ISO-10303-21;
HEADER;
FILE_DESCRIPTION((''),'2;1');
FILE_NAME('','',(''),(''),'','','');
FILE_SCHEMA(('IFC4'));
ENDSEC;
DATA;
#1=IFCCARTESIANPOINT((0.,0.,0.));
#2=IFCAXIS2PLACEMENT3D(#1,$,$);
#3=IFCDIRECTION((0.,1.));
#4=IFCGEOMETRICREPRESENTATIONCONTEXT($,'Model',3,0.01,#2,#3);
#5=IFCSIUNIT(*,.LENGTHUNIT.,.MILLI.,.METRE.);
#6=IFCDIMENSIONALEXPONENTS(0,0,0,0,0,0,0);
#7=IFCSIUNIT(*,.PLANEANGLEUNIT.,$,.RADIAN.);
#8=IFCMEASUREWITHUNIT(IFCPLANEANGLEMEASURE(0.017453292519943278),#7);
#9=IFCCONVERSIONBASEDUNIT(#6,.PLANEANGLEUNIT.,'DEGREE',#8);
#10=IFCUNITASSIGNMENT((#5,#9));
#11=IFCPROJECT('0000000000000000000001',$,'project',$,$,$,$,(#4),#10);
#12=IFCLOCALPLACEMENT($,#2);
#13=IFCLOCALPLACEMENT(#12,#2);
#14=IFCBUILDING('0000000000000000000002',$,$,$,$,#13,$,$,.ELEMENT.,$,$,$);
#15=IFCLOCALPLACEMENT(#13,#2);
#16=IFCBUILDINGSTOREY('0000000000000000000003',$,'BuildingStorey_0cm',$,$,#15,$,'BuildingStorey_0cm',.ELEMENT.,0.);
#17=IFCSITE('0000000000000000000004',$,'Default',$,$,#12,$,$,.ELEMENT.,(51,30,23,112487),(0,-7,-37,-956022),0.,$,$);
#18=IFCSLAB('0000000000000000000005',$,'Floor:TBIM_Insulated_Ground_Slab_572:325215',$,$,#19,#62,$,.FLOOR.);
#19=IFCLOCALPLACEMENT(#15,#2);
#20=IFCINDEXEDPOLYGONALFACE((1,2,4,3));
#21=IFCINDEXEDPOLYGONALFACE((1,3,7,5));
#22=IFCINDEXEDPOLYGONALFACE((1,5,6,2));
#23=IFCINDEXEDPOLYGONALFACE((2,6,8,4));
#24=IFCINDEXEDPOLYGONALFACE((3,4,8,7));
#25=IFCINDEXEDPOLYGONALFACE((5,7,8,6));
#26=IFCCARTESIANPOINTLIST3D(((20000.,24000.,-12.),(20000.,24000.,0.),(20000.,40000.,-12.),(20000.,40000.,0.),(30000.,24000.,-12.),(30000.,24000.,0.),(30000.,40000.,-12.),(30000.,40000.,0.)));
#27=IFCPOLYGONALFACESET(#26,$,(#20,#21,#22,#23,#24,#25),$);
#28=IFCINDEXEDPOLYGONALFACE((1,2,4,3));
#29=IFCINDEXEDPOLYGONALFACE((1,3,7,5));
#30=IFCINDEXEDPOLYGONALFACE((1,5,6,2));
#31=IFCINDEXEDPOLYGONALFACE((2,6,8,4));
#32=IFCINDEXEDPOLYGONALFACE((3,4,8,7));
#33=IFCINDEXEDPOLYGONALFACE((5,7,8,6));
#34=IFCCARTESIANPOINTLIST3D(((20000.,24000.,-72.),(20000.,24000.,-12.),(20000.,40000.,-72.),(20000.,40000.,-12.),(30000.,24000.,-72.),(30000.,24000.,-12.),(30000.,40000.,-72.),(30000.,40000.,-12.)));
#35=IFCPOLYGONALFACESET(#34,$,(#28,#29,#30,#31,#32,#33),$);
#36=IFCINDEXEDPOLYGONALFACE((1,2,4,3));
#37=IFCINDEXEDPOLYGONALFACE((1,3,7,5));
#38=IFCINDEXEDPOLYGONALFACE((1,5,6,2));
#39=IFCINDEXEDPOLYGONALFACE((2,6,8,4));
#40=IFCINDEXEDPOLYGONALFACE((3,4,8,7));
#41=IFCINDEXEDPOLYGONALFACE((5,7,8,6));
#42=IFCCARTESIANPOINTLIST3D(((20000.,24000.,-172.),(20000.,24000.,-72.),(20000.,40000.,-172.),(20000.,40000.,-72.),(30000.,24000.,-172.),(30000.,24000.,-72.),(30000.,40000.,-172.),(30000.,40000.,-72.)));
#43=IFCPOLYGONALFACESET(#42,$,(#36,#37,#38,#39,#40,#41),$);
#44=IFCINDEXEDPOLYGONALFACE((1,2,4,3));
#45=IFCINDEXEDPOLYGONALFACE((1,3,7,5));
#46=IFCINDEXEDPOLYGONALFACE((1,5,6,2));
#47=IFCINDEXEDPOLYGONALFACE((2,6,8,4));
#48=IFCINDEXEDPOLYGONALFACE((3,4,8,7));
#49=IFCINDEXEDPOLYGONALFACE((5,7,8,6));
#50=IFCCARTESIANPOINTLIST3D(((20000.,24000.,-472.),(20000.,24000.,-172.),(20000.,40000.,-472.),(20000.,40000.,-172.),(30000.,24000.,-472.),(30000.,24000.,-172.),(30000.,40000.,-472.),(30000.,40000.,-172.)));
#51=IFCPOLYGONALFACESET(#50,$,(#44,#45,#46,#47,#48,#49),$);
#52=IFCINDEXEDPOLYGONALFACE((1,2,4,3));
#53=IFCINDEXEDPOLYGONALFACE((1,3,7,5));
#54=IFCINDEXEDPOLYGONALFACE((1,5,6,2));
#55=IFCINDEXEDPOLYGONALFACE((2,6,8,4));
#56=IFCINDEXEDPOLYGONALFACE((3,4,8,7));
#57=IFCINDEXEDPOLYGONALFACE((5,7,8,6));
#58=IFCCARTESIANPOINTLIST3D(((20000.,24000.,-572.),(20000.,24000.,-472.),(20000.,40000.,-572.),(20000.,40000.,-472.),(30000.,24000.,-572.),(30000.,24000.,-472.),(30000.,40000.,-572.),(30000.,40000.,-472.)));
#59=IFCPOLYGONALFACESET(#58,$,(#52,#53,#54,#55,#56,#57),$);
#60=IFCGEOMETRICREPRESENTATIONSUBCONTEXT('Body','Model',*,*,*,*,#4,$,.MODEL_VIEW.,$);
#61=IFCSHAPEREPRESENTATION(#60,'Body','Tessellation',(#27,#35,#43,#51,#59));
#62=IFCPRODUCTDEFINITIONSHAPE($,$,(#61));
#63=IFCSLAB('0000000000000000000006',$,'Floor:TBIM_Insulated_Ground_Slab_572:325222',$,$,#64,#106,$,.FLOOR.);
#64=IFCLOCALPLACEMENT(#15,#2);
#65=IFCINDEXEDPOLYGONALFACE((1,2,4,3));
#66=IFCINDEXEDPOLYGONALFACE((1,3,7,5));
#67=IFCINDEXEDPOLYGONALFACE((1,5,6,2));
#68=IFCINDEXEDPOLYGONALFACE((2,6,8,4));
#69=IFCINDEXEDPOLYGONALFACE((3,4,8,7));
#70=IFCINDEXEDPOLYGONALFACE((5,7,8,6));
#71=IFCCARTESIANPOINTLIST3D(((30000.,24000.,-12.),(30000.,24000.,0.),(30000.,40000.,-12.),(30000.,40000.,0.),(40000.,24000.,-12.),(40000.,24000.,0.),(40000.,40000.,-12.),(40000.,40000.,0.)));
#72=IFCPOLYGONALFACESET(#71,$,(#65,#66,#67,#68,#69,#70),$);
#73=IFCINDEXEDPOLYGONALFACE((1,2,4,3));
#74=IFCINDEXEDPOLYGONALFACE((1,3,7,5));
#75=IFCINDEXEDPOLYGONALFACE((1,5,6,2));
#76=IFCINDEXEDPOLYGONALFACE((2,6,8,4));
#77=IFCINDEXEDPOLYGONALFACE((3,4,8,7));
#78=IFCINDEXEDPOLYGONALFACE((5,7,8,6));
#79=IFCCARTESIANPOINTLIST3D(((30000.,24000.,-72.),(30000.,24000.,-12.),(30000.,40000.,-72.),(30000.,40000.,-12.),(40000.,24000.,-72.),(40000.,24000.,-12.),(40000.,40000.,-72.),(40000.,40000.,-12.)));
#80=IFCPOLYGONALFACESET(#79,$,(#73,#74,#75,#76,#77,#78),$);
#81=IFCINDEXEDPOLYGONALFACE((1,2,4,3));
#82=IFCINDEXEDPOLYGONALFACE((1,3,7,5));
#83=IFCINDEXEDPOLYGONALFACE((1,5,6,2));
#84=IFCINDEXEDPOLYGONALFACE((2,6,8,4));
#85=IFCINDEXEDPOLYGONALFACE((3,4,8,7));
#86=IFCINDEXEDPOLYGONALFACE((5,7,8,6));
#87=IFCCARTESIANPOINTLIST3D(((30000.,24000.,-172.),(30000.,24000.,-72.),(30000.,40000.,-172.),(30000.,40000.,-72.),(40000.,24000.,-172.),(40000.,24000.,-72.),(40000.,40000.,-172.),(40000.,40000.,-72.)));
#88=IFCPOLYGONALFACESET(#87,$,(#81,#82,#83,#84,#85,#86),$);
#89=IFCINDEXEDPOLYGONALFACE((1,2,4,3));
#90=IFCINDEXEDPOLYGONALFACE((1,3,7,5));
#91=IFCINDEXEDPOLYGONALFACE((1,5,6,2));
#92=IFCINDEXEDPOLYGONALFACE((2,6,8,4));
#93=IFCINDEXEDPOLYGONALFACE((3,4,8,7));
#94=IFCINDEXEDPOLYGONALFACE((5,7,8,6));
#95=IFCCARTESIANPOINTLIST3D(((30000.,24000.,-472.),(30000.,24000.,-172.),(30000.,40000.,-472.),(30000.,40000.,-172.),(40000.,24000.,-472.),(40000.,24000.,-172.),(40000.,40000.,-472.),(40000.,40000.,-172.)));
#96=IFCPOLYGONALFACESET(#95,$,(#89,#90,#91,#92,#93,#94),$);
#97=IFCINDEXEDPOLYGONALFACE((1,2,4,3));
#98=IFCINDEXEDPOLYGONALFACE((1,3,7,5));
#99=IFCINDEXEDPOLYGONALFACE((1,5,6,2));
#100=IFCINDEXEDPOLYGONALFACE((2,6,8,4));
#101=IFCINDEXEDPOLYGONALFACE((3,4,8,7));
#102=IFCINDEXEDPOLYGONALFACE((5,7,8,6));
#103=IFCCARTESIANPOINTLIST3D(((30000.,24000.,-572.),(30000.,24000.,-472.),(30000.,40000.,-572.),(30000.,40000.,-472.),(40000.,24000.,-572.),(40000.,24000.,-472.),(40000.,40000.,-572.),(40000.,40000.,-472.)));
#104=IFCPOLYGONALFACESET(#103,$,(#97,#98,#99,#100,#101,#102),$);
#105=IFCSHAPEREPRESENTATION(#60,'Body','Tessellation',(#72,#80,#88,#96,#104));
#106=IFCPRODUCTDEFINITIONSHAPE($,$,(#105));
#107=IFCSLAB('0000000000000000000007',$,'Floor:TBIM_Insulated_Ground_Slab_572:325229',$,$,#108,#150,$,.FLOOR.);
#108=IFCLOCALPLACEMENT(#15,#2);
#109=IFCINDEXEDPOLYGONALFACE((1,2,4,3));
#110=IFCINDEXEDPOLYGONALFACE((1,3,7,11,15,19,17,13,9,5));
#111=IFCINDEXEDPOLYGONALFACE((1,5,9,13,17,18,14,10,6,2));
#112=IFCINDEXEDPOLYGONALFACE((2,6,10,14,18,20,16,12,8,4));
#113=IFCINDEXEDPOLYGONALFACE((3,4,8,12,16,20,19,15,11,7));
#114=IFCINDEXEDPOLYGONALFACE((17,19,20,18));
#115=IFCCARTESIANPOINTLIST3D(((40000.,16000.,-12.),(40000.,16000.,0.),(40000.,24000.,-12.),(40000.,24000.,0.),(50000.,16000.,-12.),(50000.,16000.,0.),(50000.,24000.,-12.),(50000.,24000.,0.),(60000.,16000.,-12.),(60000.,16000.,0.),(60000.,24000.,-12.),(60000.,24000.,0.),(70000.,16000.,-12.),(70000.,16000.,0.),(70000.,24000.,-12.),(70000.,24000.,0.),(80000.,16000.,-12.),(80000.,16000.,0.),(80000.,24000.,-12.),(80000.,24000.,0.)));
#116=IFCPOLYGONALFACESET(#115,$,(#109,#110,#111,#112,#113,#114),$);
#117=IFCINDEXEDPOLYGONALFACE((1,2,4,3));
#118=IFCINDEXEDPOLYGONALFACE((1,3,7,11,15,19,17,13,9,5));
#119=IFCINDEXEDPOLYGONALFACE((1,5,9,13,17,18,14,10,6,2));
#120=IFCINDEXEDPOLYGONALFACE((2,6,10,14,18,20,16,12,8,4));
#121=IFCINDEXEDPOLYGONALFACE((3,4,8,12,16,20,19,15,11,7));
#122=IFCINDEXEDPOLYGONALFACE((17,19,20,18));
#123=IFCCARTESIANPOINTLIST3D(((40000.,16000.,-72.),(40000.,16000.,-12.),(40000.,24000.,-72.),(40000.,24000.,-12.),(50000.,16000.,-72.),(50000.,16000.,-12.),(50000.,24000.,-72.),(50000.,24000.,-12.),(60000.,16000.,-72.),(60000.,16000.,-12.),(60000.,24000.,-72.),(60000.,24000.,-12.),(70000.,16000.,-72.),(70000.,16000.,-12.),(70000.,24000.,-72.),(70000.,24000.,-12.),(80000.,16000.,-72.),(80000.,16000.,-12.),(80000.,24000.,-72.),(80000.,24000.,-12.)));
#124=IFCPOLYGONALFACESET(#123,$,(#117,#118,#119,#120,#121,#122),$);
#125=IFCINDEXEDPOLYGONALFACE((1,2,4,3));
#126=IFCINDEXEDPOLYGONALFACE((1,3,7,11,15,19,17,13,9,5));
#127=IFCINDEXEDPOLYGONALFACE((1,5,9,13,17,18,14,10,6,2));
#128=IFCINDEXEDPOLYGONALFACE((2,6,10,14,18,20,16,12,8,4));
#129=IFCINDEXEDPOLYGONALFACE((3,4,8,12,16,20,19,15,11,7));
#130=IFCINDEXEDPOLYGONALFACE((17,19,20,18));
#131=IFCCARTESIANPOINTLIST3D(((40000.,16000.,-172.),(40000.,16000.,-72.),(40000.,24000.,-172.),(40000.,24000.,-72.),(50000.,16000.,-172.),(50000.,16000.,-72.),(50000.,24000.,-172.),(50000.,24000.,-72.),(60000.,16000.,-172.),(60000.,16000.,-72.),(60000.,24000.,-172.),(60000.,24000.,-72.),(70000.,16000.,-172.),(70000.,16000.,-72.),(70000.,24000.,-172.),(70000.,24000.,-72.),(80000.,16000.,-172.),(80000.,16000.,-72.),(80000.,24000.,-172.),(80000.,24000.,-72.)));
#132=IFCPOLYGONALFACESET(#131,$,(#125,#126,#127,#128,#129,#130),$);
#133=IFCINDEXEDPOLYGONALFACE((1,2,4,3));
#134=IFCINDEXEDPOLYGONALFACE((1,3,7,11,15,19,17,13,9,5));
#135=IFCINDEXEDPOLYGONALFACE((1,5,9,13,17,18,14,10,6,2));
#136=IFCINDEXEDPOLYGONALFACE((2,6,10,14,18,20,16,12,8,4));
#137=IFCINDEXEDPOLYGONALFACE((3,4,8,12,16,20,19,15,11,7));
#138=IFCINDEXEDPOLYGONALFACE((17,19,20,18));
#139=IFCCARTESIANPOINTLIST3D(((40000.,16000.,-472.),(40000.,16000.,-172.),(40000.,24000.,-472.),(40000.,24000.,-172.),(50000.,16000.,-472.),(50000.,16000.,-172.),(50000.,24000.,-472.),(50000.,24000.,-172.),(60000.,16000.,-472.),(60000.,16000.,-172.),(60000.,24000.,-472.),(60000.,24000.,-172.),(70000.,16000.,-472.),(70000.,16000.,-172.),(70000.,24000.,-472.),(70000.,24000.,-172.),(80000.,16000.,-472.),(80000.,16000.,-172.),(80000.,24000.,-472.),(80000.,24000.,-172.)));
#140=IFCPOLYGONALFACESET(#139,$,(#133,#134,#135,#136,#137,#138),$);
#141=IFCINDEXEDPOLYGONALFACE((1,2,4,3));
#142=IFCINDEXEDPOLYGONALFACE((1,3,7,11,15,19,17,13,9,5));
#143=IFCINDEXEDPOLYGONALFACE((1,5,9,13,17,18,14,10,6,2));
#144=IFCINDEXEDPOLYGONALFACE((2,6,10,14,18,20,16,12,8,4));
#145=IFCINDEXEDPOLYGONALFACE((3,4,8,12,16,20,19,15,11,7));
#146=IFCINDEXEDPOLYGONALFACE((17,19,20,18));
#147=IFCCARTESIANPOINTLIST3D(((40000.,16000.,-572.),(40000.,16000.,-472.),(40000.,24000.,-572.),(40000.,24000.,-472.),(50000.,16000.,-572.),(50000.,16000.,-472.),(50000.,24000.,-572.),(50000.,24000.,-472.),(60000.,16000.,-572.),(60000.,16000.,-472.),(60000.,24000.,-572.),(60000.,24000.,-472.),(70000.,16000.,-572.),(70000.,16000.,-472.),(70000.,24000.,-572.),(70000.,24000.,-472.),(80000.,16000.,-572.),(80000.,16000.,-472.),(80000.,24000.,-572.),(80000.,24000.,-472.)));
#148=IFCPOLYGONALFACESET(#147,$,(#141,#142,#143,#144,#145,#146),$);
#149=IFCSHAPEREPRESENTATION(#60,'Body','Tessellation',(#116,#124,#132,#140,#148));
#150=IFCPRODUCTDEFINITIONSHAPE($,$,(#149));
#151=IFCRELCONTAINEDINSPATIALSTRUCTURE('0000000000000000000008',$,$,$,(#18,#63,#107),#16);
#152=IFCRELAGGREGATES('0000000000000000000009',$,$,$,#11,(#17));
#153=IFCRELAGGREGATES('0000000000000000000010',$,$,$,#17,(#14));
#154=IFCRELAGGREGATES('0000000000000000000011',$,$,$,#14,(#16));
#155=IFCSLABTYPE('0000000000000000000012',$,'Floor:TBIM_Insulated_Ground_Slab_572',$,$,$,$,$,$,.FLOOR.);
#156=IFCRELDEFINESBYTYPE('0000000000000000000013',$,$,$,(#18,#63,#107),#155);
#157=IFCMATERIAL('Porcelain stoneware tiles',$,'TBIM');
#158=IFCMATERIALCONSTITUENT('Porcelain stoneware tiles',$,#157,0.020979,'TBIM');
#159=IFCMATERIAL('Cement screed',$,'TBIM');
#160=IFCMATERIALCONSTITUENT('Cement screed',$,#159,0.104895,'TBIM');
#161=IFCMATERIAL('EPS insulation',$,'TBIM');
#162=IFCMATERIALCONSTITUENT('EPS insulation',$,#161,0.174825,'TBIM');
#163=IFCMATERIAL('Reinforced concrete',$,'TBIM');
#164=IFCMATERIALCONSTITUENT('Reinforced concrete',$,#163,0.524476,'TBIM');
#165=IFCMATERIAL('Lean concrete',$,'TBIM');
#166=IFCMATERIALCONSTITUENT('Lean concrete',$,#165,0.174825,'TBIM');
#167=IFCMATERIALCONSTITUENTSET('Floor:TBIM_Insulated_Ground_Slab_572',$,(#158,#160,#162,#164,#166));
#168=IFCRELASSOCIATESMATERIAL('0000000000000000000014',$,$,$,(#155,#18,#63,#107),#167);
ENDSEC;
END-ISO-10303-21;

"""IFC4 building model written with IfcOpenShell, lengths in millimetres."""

from ifc_helpers import new_model, entity, si_unit, converted_unit, direction, frame, origin, place, context, subcontext, project, spatial, indexed_curve, outline, extrude, material, constituent, constituent_set, type_object, element, save


model = new_model("IFC4")

# Units and contexts
model_context = context("Model", 3, precision=0.01, world=origin(), true_north=direction((0.0, 1.0)))
body_context = subcontext(model_context, "Body", "Model", "MODEL_VIEW")
ifc_project = project(units=[si_unit("LENGTHUNIT", "METRE", prefix="MILLI"), converted_unit("PLANEANGLEUNIT", "DEGREE", entity("IfcPlaneAngleMeasure", 0.017453292519943278), si_unit("PLANEANGLEUNIT", "RADIAN"), dimensions=[0, 0, 0, 0, 0, 0, 0])], contexts=[model_context])

# Site, building, storey
site_placement = place(None, origin())
site = spatial("IfcSite", under=ifc_project, at=site_placement, Name="Default", CompositionType="ELEMENT", RefLatitude=(51, 30, 23, 112487), RefLongitude=(0, -7, -37, -956022), RefElevation=0.0)
building_placement = place(site_placement, origin())
building = spatial("IfcBuilding", under=site, at=building_placement, CompositionType="ELEMENT")
storey_placement = place(building_placement, origin())
storey = spatial("IfcBuildingStorey", under=building, at=storey_placement, Name="BuildingStorey_0cm", LongName="BuildingStorey_0cm", CompositionType="ELEMENT", Elevation=0.0)

# Slabs
ifc_material_1 = material(Name="Porcelain stoneware tiles", Category="TBIM")
ifc_constituent_1 = constituent(ifc_material_1, Name="Porcelain stoneware tiles", Category="TBIM", fraction=0.020979)
ifc_material_2 = material(Name="Cement screed", Category="TBIM")
ifc_constituent_2 = constituent(ifc_material_2, Name="Cement screed", Category="TBIM", fraction=0.104895)
ifc_material_3 = material(Name="EPS insulation", Category="TBIM")
ifc_constituent_3 = constituent(ifc_material_3, Name="EPS insulation", Category="TBIM", fraction=0.174825)
ifc_material_4 = material(Name="Reinforced concrete", Category="TBIM")
ifc_constituent_4 = constituent(ifc_material_4, Name="Reinforced concrete", Category="TBIM", fraction=0.524476)
ifc_material_5 = material(Name="Lean concrete", Category="TBIM")
ifc_constituent_5 = constituent(ifc_material_5, Name="Lean concrete", Category="TBIM", fraction=0.174825)
ifc_constituent_set_1 = constituent_set(constituents=[ifc_constituent_1, ifc_constituent_2, ifc_constituent_3, ifc_constituent_4, ifc_constituent_5], Name="Floor:TBIM_Insulated_Ground_Slab_572")
slab_type = type_object("IfcSlabType", Name="Floor:TBIM_Insulated_Ground_Slab_572", PredefinedType="FLOOR", material=ifc_constituent_set_1)
slab_1_placement = place(storey_placement, origin())
element("IfcSlab", 1, at=slab_1_placement, inside=storey, type_object=slab_type, material=ifc_constituent_set_1, Name="Floor:TBIM_Insulated_Ground_Slab_572:325215", PredefinedType="FLOOR", context=body_context, shape_type="SweptSolid", body=[
    extrude(outline(indexed_curve([(-5000.0, -8000.0), (5000.0, -8000.0), (5000.0, 8000.0), (-5000.0, 8000.0), (-5000.0, -8000.0)], self_intersect=False)), frame((25000.0, 32000.0, -12.0), z_axis=(0.0, 0.0, 1.0), x_axis=(-1.0, 0.0, 0.0)), (0.0, 0.0, 1.0), 12.0),
    extrude(outline(indexed_curve([(-5000.0, -8000.0), (5000.0, -8000.0), (5000.0, 8000.0), (-5000.0, 8000.0), (-5000.0, -8000.0)], self_intersect=False)), frame((25000.0, 32000.0, -72.0), z_axis=(0.0, 0.0, 1.0), x_axis=(-1.0, 0.0, 0.0)), (0.0, 0.0, 1.0), 60.0),
    extrude(outline(indexed_curve([(-5000.0, -8000.0), (5000.0, -8000.0), (5000.0, 8000.0), (-5000.0, 8000.0), (-5000.0, -8000.0)], self_intersect=False)), frame((25000.0, 32000.0, -172.0), z_axis=(0.0, 0.0, 1.0), x_axis=(-1.0, 0.0, 0.0)), (0.0, 0.0, 1.0), 100.0),
    extrude(outline(indexed_curve([(-5000.0, -8000.0), (5000.0, -8000.0), (5000.0, 8000.0), (-5000.0, 8000.0), (-5000.0, -8000.0)], self_intersect=False)), frame((25000.0, 32000.0, -472.0), z_axis=(0.0, 0.0, 1.0), x_axis=(-1.0, 0.0, 0.0)), (0.0, 0.0, 1.0), 300.0),
    extrude(outline(indexed_curve([(-5000.0, -8000.0), (5000.0, -8000.0), (5000.0, 8000.0), (-5000.0, 8000.0), (-5000.0, -8000.0)], self_intersect=False)), frame((25000.0, 32000.0, -572.0), z_axis=(0.0, 0.0, 1.0), x_axis=(-1.0, 0.0, 0.0)), (0.0, 0.0, 1.0), 100.0),
])
slab_2_placement = place(storey_placement, origin())
element("IfcSlab", 2, at=slab_2_placement, inside=storey, type_object=slab_type, material=ifc_constituent_set_1, Name="Floor:TBIM_Insulated_Ground_Slab_572:325222", PredefinedType="FLOOR", context=body_context, shape_type="SweptSolid", body=[
    extrude(outline(indexed_curve([(-5000.0, -8000.0), (5000.0, -8000.0), (5000.0, 8000.0), (-5000.0, 8000.0), (-5000.0, -8000.0)], self_intersect=False)), frame((35000.0, 32000.0, -12.0), z_axis=(0.0, 0.0, 1.0), x_axis=(-1.0, 0.0, 0.0)), (0.0, 0.0, 1.0), 12.0),
    extrude(outline(indexed_curve([(-5000.0, -8000.0), (5000.0, -8000.0), (5000.0, 8000.0), (-5000.0, 8000.0), (-5000.0, -8000.0)], self_intersect=False)), frame((35000.0, 32000.0, -72.0), z_axis=(0.0, 0.0, 1.0), x_axis=(-1.0, 0.0, 0.0)), (0.0, 0.0, 1.0), 60.0),
    extrude(outline(indexed_curve([(-5000.0, -8000.0), (5000.0, -8000.0), (5000.0, 8000.0), (-5000.0, 8000.0), (-5000.0, -8000.0)], self_intersect=False)), frame((35000.0, 32000.0, -172.0), z_axis=(0.0, 0.0, 1.0), x_axis=(-1.0, 0.0, 0.0)), (0.0, 0.0, 1.0), 100.0),
    extrude(outline(indexed_curve([(-5000.0, -8000.0), (5000.0, -8000.0), (5000.0, 8000.0), (-5000.0, 8000.0), (-5000.0, -8000.0)], self_intersect=False)), frame((35000.0, 32000.0, -472.0), z_axis=(0.0, 0.0, 1.0), x_axis=(-1.0, 0.0, 0.0)), (0.0, 0.0, 1.0), 300.0),
    extrude(outline(indexed_curve([(-5000.0, -8000.0), (5000.0, -8000.0), (5000.0, 8000.0), (-5000.0, 8000.0), (-5000.0, -8000.0)], self_intersect=False)), frame((35000.0, 32000.0, -572.0), z_axis=(0.0, 0.0, 1.0), x_axis=(-1.0, 0.0, 0.0)), (0.0, 0.0, 1.0), 100.0),
])
slab_3_placement = place(storey_placement, origin())
element("IfcSlab", 3, at=slab_3_placement, inside=storey, type_object=slab_type, material=ifc_constituent_set_1, Name="Floor:TBIM_Insulated_Ground_Slab_572:325229", PredefinedType="FLOOR", context=body_context, shape_type="SweptSolid", body=[
    extrude(outline(indexed_curve([(0.0, -4000.0), (10000.0, -4000.0), (20000.0, -4000.0), (20000.0, 4000.0), (10000.0, 4000.0), (0.0, 4000.0), (-10000.0, 4000.0), (-20000.0, 4000.0), (-20000.0, -4000.0), (-10000.0, -4000.0), (0.0, -4000.0)], self_intersect=False)), frame((60000.0, 20000.0, -12.0), z_axis=(0.0, 0.0, 1.0), x_axis=(-1.0, 0.0, 0.0)), (0.0, 0.0, 1.0), 12.0),
    extrude(outline(indexed_curve([(0.0, -4000.0), (10000.0, -4000.0), (20000.0, -4000.0), (20000.0, 4000.0), (10000.0, 4000.0), (0.0, 4000.0), (-10000.0, 4000.0), (-20000.0, 4000.0), (-20000.0, -4000.0), (-10000.0, -4000.0), (0.0, -4000.0)], self_intersect=False)), frame((60000.0, 20000.0, -72.0), z_axis=(0.0, 0.0, 1.0), x_axis=(-1.0, 0.0, 0.0)), (0.0, 0.0, 1.0), 60.0),
    extrude(outline(indexed_curve([(0.0, -4000.0), (10000.0, -4000.0), (20000.0, -4000.0), (20000.0, 4000.0), (10000.0, 4000.0), (0.0, 4000.0), (-10000.0, 4000.0), (-20000.0, 4000.0), (-20000.0, -4000.0), (-10000.0, -4000.0), (0.0, -4000.0)], self_intersect=False)), frame((60000.0, 20000.0, -172.0), z_axis=(0.0, 0.0, 1.0), x_axis=(-1.0, 0.0, 0.0)), (0.0, 0.0, 1.0), 100.0),
    extrude(outline(indexed_curve([(0.0, -4000.0), (10000.0, -4000.0), (20000.0, -4000.0), (20000.0, 4000.0), (10000.0, 4000.0), (0.0, 4000.0), (-10000.0, 4000.0), (-20000.0, 4000.0), (-20000.0, -4000.0), (-10000.0, -4000.0), (0.0, -4000.0)], self_intersect=False)), frame((60000.0, 20000.0, -472.0), z_axis=(0.0, 0.0, 1.0), x_axis=(-1.0, 0.0, 0.0)), (0.0, 0.0, 1.0), 300.0),
    extrude(outline(indexed_curve([(0.0, -4000.0), (10000.0, -4000.0), (20000.0, -4000.0), (20000.0, 4000.0), (10000.0, 4000.0), (0.0, 4000.0), (-10000.0, 4000.0), (-20000.0, 4000.0), (-20000.0, -4000.0), (-10000.0, -4000.0), (0.0, -4000.0)], self_intersect=False)), frame((60000.0, 20000.0, -572.0), z_axis=(0.0, 0.0, 1.0), x_axis=(-1.0, 0.0, 0.0)), (0.0, 0.0, 1.0), 100.0),
])

save(model, "model.ifc")
